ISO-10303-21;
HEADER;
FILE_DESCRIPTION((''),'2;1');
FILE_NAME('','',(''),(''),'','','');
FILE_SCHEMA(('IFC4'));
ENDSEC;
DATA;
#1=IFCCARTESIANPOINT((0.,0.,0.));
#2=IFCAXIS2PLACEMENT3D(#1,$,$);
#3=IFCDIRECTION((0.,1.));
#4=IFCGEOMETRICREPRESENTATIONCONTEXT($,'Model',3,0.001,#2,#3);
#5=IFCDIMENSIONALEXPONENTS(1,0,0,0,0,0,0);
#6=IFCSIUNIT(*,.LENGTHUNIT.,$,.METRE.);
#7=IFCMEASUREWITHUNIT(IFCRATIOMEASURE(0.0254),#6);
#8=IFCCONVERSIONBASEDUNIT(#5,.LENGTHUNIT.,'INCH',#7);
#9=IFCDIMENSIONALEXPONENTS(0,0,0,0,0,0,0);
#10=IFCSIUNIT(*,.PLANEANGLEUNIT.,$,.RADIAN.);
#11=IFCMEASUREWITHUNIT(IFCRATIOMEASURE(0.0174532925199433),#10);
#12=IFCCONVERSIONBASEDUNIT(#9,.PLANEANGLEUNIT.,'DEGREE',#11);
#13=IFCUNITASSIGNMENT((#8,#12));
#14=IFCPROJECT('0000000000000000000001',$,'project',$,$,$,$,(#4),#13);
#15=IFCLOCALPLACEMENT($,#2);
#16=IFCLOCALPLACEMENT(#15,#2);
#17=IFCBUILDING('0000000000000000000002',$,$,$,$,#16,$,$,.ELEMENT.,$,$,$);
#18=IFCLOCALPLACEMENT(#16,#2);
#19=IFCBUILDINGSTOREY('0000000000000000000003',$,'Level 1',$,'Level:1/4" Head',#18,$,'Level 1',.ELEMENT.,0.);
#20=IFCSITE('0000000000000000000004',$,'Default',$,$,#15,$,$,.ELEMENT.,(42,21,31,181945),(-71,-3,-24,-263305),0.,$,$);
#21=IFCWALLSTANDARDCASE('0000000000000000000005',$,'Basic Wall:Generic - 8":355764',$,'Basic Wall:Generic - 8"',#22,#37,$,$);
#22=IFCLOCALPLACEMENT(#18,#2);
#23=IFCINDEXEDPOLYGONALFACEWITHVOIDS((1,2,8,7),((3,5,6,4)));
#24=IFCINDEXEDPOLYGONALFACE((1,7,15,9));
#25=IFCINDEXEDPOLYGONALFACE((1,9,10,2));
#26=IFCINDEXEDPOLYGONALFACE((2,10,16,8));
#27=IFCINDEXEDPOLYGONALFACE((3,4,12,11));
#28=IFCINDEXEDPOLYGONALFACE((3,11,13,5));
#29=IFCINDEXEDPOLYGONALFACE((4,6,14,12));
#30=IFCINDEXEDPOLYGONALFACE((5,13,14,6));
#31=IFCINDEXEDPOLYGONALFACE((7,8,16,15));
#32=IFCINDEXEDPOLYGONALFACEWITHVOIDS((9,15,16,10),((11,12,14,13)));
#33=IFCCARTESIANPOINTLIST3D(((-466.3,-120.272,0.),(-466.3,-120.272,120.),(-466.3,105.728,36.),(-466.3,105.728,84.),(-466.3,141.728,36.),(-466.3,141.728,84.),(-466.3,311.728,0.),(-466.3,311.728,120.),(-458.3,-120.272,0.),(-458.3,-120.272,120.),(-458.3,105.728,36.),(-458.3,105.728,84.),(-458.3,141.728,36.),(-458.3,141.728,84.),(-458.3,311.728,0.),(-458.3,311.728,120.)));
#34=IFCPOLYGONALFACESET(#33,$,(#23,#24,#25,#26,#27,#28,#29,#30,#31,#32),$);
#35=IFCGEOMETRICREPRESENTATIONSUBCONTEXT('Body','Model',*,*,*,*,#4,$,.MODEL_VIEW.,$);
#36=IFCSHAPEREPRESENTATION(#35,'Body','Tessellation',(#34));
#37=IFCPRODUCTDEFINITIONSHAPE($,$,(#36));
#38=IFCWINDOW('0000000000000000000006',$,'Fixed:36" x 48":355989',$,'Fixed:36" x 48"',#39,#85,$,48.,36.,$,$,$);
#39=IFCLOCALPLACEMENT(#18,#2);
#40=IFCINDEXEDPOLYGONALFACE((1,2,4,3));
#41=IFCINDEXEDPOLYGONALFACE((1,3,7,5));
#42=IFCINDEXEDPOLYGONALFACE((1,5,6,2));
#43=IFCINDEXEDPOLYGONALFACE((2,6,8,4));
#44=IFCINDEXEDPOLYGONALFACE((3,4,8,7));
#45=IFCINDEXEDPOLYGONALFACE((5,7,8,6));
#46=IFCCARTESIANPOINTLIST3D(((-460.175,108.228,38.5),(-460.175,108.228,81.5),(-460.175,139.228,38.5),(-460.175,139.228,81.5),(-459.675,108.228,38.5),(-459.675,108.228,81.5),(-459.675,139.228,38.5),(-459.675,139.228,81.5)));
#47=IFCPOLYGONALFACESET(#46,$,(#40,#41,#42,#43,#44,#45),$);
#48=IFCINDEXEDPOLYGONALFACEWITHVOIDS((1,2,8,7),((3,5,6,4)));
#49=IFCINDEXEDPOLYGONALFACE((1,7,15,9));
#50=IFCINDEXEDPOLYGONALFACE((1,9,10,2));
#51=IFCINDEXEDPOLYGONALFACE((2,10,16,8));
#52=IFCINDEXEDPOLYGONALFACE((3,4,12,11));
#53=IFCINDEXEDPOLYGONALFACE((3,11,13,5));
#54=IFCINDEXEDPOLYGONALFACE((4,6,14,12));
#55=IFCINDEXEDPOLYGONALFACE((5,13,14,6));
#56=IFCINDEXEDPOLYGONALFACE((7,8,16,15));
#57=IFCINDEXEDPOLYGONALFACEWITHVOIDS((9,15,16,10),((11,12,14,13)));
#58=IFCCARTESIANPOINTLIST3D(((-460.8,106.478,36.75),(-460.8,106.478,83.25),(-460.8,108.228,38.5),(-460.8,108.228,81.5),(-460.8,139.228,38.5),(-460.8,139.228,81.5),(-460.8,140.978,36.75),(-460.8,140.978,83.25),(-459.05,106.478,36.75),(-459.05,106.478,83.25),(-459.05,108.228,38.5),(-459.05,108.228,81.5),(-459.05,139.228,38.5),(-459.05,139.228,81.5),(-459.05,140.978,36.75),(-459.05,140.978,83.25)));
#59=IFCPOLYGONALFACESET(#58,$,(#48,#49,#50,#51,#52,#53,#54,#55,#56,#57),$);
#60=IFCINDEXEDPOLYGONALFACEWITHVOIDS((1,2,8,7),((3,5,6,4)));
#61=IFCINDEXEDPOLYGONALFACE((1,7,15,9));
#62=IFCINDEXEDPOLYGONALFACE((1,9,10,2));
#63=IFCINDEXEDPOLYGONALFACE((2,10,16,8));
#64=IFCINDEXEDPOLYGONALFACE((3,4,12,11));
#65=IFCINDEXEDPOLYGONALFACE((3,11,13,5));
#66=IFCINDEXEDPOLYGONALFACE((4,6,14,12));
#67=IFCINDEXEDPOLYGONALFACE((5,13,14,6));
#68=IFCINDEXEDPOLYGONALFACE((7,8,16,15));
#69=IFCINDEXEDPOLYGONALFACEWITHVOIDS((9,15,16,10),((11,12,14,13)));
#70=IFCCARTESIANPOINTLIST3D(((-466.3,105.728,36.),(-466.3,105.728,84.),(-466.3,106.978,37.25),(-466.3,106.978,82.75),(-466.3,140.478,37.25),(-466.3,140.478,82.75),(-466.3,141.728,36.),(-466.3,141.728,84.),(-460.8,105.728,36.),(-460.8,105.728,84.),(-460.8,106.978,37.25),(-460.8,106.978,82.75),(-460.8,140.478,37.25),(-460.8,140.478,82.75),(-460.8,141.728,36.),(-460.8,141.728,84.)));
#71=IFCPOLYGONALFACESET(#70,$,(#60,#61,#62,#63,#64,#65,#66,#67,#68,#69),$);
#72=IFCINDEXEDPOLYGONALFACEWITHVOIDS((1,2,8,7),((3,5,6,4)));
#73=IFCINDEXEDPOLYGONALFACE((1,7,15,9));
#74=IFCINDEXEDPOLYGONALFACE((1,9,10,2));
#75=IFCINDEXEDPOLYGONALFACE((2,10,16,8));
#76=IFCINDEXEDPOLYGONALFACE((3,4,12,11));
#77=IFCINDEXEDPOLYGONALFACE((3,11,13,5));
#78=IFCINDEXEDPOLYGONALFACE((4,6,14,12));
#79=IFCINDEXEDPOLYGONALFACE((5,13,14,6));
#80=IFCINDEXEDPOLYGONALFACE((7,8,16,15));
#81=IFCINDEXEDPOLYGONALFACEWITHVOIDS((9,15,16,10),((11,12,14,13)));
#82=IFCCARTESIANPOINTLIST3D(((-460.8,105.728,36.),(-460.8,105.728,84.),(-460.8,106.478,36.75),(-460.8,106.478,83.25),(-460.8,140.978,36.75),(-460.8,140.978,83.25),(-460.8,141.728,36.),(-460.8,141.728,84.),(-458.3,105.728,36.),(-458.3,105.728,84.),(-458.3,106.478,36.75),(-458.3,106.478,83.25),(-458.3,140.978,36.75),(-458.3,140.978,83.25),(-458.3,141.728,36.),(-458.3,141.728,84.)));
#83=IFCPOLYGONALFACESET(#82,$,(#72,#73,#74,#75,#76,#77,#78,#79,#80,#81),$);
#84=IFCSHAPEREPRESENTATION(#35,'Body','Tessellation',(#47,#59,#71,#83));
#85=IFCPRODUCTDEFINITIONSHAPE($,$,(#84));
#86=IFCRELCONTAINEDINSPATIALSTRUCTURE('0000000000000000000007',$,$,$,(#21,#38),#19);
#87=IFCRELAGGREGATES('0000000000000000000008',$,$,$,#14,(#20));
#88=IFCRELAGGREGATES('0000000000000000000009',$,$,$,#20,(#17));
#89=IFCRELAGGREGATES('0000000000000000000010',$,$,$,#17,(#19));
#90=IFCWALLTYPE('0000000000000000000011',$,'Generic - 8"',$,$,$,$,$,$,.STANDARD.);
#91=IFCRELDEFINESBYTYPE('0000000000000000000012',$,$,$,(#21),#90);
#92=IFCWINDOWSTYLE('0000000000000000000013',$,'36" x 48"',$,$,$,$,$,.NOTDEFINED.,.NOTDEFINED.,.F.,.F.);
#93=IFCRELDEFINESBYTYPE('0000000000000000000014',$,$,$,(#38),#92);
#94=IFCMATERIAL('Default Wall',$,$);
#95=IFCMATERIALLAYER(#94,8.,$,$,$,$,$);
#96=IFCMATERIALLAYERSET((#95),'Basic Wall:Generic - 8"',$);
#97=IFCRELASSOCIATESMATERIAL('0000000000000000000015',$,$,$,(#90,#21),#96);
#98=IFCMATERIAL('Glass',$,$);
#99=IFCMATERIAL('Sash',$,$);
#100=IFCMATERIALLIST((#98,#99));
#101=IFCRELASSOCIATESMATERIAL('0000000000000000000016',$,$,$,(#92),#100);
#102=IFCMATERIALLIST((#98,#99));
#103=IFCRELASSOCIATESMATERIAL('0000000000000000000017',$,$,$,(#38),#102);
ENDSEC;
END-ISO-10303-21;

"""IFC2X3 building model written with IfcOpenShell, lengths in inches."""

from ifc_helpers import new_model, entity, si_unit, converted_unit, direction, frame, frame_2d, origin, place, context, subcontext, project, spatial, polyline, rectangle, outline, extrude, clip, halfspace, source, transform, mapped, material, material_list, layer, layer_set, layer_usage, type_object, type_shapes, element, fill, save


model = new_model("IFC2X3")

# Units and contexts
model_context = context("Model", 3, precision=0.001, world=origin(), true_north=direction((0.0, 1.0)))
body_context = subcontext(model_context, "Body", "Model", "MODEL_VIEW")
ifc_project = project(units=[converted_unit("LENGTHUNIT", "INCH", entity("IfcRatioMeasure", 0.0254), si_unit("LENGTHUNIT", "METRE"), dimensions=[1, 0, 0, 0, 0, 0, 0]), converted_unit("PLANEANGLEUNIT", "DEGREE", entity("IfcRatioMeasure", 0.0174532925199433), si_unit("PLANEANGLEUNIT", "RADIAN"), dimensions=[0, 0, 0, 0, 0, 0, 0])], contexts=[model_context])

# Site, building, storey
site_placement = place(None, origin())
site = spatial("IfcSite", under=ifc_project, at=site_placement, Name="Default", CompositionType="ELEMENT", RefLatitude=(42, 21, 31, 181945), RefLongitude=(-71, -3, -24, -263305), RefElevation=0.0)
building_placement = place(site_placement, origin())
building = spatial("IfcBuilding", under=site, at=building_placement, CompositionType="ELEMENT")
storey_placement = place(building_placement, origin())
storey = spatial("IfcBuildingStorey", under=building, at=storey_placement, Name="Level 1", ObjectType="Level:1/4\" Head", LongName="Level 1", CompositionType="ELEMENT", Elevation=0.0)

# Shared definitions
ifc_material_1 = material(Name="Default Wall")
ifc_layer = layer(ifc_material_1, 8.0)
ifc_layer_set = layer_set([ifc_layer], Name="Basic Wall:Generic - 8\"")
wall_type = type_object("IfcWallType", Name="Generic - 8\"", PredefinedType="STANDARD", material=ifc_layer_set)
ifc_material_2 = material(Name="Glass")
ifc_material_3 = material(Name="Sash")
ifc_material_list_1 = material_list([ifc_material_2, ifc_material_3])
window_style = type_object("IfcWindowStyle", Name="36\" x 48\"", ConstructionType="NOTDEFINED", OperationType="NOTDEFINED", ParameterTakesPrecedence=False, Sizeable=False, material=ifc_material_list_1)
shared_shape_1 = source(origin(), body_context, "Body", "SweptSolid", [
    extrude(rectangle(XDim=0.5, YDim=31.0, at=frame_2d((0.0, 0.0), x_axis=(1.0, 0.0))), frame((18.0, 6.375, 2.5), z_axis=(0.0, 0.0, 1.0), x_axis=(0.0, 1.0, 0.0)), (0.0, 0.0, 1.0), 43.0),
    extrude(outline(polyline([(-17.25, -23.25), (17.25, -23.25), (17.25, 23.25), (-17.25, 23.25), (-17.25, -23.25)]), holes=[polyline([(-15.5, -21.5), (-15.5, 21.5), (15.5, 21.5), (15.5, -21.5), (-15.5, -21.5)])]), frame((18.0, 5.5, 24.0), z_axis=(0.0, 1.0, 0.0), x_axis=(1.0, 0.0, 0.0)), (0.0, 0.0, 1.0), 1.75),
    extrude(outline(polyline([(-18.0, -24.0), (18.0, -24.0), (18.0, 24.0), (-18.0, 24.0), (-18.0, -24.0)]), holes=[polyline([(-16.75, -22.75), (-16.75, 22.75), (16.75, 22.75), (16.75, -22.75), (-16.75, -22.75)])]), frame((18.0, 0.0, 24.0), z_axis=(0.0, 1.0, 0.0), x_axis=(1.0, 0.0, 0.0)), (0.0, 0.0, 1.0), 5.5),
    extrude(outline(polyline([(-24.0, -18.0), (24.0, -18.0), (24.0, 18.0), (-24.0, 18.0), (-24.0, -18.0)]), holes=[polyline([(-23.25, -17.25), (-23.25, 17.25), (23.25, 17.25), (23.25, -17.25), (-23.25, -17.25)])]), frame((18.0, 5.5, 24.0), z_axis=(0.0, 1.0, 0.0), x_axis=(0.0, 0.0, -1.0)), (0.0, 0.0, 1.0), 2.5),
])
type_shapes(window_style, [shared_shape_1])

# Wall, opening, window
ifc_layer_usage_1 = layer_usage(ifc_layer_set, "AXIS2", "NEGATIVE", 4.0)
wall_1_placement = place(storey_placement, frame((-462.3, -120.272, 0.0), z_axis=(0.0, 0.0, 1.0), x_axis=(0.0, 1.0, 0.0)))
wall_1 = element("IfcWallStandardCase", 1, at=wall_1_placement, inside=storey, type_object=wall_type, material=ifc_layer_usage_1, Name="Basic Wall:Generic - 8\":355764", ObjectType="Basic Wall:Generic - 8\"", context=body_context, shape_type="Clipping", body=[
    clip(extrude(rectangle(XDim=432.0, YDim=8.0, at=frame_2d((216.0, 0.0), x_axis=(-1.0, 0.0))), origin(), (0.0, 0.0, 1.0), 120.0), halfspace(origin(), True)),
])
opening_1_placement = place(wall_1_placement, frame((262.0, 4.0, 36.0)))
opening_1 = element("IfcOpeningElement", 2, at=opening_1_placement, cuts=wall_1, ObjectType="Opening", context=body_context, shape_type="SweptSolid", body=[
    extrude(rectangle(XDim=48.0, YDim=36.0, at=frame_2d((24.0, 18.0), x_axis=(-1.0, 0.0))), frame((0.0, 0.0, 0.0), z_axis=(0.0, -1.0, 0.0), x_axis=(0.0, 0.0, 1.0)), (0.0, 0.0, 1.0), 8.0),
])
ifc_material_list_2 = material_list([ifc_material_2, ifc_material_3])
window_1_placement = place(opening_1_placement, frame((0.0, 0.0, 0.0), z_axis=(0.0, 0.0, 1.0), x_axis=(-1.0, 0.0, 0.0)))
window_1 = element("IfcWindow", 3, at=window_1_placement, inside=storey, type_object=window_style, material=ifc_material_list_2, Name="Fixed:36\" x 48\":355989", ObjectType="Fixed:36\" x 48\"", OverallHeight=48.0, OverallWidth=36.0, context=body_context, shape_type="MappedRepresentation", body=[
    mapped(shared_shape_1, transform((0.0, 0.0, 0.0), scale=1.0)),
])
fill(opening_1, window_1)

save(model, "model.ifc")
